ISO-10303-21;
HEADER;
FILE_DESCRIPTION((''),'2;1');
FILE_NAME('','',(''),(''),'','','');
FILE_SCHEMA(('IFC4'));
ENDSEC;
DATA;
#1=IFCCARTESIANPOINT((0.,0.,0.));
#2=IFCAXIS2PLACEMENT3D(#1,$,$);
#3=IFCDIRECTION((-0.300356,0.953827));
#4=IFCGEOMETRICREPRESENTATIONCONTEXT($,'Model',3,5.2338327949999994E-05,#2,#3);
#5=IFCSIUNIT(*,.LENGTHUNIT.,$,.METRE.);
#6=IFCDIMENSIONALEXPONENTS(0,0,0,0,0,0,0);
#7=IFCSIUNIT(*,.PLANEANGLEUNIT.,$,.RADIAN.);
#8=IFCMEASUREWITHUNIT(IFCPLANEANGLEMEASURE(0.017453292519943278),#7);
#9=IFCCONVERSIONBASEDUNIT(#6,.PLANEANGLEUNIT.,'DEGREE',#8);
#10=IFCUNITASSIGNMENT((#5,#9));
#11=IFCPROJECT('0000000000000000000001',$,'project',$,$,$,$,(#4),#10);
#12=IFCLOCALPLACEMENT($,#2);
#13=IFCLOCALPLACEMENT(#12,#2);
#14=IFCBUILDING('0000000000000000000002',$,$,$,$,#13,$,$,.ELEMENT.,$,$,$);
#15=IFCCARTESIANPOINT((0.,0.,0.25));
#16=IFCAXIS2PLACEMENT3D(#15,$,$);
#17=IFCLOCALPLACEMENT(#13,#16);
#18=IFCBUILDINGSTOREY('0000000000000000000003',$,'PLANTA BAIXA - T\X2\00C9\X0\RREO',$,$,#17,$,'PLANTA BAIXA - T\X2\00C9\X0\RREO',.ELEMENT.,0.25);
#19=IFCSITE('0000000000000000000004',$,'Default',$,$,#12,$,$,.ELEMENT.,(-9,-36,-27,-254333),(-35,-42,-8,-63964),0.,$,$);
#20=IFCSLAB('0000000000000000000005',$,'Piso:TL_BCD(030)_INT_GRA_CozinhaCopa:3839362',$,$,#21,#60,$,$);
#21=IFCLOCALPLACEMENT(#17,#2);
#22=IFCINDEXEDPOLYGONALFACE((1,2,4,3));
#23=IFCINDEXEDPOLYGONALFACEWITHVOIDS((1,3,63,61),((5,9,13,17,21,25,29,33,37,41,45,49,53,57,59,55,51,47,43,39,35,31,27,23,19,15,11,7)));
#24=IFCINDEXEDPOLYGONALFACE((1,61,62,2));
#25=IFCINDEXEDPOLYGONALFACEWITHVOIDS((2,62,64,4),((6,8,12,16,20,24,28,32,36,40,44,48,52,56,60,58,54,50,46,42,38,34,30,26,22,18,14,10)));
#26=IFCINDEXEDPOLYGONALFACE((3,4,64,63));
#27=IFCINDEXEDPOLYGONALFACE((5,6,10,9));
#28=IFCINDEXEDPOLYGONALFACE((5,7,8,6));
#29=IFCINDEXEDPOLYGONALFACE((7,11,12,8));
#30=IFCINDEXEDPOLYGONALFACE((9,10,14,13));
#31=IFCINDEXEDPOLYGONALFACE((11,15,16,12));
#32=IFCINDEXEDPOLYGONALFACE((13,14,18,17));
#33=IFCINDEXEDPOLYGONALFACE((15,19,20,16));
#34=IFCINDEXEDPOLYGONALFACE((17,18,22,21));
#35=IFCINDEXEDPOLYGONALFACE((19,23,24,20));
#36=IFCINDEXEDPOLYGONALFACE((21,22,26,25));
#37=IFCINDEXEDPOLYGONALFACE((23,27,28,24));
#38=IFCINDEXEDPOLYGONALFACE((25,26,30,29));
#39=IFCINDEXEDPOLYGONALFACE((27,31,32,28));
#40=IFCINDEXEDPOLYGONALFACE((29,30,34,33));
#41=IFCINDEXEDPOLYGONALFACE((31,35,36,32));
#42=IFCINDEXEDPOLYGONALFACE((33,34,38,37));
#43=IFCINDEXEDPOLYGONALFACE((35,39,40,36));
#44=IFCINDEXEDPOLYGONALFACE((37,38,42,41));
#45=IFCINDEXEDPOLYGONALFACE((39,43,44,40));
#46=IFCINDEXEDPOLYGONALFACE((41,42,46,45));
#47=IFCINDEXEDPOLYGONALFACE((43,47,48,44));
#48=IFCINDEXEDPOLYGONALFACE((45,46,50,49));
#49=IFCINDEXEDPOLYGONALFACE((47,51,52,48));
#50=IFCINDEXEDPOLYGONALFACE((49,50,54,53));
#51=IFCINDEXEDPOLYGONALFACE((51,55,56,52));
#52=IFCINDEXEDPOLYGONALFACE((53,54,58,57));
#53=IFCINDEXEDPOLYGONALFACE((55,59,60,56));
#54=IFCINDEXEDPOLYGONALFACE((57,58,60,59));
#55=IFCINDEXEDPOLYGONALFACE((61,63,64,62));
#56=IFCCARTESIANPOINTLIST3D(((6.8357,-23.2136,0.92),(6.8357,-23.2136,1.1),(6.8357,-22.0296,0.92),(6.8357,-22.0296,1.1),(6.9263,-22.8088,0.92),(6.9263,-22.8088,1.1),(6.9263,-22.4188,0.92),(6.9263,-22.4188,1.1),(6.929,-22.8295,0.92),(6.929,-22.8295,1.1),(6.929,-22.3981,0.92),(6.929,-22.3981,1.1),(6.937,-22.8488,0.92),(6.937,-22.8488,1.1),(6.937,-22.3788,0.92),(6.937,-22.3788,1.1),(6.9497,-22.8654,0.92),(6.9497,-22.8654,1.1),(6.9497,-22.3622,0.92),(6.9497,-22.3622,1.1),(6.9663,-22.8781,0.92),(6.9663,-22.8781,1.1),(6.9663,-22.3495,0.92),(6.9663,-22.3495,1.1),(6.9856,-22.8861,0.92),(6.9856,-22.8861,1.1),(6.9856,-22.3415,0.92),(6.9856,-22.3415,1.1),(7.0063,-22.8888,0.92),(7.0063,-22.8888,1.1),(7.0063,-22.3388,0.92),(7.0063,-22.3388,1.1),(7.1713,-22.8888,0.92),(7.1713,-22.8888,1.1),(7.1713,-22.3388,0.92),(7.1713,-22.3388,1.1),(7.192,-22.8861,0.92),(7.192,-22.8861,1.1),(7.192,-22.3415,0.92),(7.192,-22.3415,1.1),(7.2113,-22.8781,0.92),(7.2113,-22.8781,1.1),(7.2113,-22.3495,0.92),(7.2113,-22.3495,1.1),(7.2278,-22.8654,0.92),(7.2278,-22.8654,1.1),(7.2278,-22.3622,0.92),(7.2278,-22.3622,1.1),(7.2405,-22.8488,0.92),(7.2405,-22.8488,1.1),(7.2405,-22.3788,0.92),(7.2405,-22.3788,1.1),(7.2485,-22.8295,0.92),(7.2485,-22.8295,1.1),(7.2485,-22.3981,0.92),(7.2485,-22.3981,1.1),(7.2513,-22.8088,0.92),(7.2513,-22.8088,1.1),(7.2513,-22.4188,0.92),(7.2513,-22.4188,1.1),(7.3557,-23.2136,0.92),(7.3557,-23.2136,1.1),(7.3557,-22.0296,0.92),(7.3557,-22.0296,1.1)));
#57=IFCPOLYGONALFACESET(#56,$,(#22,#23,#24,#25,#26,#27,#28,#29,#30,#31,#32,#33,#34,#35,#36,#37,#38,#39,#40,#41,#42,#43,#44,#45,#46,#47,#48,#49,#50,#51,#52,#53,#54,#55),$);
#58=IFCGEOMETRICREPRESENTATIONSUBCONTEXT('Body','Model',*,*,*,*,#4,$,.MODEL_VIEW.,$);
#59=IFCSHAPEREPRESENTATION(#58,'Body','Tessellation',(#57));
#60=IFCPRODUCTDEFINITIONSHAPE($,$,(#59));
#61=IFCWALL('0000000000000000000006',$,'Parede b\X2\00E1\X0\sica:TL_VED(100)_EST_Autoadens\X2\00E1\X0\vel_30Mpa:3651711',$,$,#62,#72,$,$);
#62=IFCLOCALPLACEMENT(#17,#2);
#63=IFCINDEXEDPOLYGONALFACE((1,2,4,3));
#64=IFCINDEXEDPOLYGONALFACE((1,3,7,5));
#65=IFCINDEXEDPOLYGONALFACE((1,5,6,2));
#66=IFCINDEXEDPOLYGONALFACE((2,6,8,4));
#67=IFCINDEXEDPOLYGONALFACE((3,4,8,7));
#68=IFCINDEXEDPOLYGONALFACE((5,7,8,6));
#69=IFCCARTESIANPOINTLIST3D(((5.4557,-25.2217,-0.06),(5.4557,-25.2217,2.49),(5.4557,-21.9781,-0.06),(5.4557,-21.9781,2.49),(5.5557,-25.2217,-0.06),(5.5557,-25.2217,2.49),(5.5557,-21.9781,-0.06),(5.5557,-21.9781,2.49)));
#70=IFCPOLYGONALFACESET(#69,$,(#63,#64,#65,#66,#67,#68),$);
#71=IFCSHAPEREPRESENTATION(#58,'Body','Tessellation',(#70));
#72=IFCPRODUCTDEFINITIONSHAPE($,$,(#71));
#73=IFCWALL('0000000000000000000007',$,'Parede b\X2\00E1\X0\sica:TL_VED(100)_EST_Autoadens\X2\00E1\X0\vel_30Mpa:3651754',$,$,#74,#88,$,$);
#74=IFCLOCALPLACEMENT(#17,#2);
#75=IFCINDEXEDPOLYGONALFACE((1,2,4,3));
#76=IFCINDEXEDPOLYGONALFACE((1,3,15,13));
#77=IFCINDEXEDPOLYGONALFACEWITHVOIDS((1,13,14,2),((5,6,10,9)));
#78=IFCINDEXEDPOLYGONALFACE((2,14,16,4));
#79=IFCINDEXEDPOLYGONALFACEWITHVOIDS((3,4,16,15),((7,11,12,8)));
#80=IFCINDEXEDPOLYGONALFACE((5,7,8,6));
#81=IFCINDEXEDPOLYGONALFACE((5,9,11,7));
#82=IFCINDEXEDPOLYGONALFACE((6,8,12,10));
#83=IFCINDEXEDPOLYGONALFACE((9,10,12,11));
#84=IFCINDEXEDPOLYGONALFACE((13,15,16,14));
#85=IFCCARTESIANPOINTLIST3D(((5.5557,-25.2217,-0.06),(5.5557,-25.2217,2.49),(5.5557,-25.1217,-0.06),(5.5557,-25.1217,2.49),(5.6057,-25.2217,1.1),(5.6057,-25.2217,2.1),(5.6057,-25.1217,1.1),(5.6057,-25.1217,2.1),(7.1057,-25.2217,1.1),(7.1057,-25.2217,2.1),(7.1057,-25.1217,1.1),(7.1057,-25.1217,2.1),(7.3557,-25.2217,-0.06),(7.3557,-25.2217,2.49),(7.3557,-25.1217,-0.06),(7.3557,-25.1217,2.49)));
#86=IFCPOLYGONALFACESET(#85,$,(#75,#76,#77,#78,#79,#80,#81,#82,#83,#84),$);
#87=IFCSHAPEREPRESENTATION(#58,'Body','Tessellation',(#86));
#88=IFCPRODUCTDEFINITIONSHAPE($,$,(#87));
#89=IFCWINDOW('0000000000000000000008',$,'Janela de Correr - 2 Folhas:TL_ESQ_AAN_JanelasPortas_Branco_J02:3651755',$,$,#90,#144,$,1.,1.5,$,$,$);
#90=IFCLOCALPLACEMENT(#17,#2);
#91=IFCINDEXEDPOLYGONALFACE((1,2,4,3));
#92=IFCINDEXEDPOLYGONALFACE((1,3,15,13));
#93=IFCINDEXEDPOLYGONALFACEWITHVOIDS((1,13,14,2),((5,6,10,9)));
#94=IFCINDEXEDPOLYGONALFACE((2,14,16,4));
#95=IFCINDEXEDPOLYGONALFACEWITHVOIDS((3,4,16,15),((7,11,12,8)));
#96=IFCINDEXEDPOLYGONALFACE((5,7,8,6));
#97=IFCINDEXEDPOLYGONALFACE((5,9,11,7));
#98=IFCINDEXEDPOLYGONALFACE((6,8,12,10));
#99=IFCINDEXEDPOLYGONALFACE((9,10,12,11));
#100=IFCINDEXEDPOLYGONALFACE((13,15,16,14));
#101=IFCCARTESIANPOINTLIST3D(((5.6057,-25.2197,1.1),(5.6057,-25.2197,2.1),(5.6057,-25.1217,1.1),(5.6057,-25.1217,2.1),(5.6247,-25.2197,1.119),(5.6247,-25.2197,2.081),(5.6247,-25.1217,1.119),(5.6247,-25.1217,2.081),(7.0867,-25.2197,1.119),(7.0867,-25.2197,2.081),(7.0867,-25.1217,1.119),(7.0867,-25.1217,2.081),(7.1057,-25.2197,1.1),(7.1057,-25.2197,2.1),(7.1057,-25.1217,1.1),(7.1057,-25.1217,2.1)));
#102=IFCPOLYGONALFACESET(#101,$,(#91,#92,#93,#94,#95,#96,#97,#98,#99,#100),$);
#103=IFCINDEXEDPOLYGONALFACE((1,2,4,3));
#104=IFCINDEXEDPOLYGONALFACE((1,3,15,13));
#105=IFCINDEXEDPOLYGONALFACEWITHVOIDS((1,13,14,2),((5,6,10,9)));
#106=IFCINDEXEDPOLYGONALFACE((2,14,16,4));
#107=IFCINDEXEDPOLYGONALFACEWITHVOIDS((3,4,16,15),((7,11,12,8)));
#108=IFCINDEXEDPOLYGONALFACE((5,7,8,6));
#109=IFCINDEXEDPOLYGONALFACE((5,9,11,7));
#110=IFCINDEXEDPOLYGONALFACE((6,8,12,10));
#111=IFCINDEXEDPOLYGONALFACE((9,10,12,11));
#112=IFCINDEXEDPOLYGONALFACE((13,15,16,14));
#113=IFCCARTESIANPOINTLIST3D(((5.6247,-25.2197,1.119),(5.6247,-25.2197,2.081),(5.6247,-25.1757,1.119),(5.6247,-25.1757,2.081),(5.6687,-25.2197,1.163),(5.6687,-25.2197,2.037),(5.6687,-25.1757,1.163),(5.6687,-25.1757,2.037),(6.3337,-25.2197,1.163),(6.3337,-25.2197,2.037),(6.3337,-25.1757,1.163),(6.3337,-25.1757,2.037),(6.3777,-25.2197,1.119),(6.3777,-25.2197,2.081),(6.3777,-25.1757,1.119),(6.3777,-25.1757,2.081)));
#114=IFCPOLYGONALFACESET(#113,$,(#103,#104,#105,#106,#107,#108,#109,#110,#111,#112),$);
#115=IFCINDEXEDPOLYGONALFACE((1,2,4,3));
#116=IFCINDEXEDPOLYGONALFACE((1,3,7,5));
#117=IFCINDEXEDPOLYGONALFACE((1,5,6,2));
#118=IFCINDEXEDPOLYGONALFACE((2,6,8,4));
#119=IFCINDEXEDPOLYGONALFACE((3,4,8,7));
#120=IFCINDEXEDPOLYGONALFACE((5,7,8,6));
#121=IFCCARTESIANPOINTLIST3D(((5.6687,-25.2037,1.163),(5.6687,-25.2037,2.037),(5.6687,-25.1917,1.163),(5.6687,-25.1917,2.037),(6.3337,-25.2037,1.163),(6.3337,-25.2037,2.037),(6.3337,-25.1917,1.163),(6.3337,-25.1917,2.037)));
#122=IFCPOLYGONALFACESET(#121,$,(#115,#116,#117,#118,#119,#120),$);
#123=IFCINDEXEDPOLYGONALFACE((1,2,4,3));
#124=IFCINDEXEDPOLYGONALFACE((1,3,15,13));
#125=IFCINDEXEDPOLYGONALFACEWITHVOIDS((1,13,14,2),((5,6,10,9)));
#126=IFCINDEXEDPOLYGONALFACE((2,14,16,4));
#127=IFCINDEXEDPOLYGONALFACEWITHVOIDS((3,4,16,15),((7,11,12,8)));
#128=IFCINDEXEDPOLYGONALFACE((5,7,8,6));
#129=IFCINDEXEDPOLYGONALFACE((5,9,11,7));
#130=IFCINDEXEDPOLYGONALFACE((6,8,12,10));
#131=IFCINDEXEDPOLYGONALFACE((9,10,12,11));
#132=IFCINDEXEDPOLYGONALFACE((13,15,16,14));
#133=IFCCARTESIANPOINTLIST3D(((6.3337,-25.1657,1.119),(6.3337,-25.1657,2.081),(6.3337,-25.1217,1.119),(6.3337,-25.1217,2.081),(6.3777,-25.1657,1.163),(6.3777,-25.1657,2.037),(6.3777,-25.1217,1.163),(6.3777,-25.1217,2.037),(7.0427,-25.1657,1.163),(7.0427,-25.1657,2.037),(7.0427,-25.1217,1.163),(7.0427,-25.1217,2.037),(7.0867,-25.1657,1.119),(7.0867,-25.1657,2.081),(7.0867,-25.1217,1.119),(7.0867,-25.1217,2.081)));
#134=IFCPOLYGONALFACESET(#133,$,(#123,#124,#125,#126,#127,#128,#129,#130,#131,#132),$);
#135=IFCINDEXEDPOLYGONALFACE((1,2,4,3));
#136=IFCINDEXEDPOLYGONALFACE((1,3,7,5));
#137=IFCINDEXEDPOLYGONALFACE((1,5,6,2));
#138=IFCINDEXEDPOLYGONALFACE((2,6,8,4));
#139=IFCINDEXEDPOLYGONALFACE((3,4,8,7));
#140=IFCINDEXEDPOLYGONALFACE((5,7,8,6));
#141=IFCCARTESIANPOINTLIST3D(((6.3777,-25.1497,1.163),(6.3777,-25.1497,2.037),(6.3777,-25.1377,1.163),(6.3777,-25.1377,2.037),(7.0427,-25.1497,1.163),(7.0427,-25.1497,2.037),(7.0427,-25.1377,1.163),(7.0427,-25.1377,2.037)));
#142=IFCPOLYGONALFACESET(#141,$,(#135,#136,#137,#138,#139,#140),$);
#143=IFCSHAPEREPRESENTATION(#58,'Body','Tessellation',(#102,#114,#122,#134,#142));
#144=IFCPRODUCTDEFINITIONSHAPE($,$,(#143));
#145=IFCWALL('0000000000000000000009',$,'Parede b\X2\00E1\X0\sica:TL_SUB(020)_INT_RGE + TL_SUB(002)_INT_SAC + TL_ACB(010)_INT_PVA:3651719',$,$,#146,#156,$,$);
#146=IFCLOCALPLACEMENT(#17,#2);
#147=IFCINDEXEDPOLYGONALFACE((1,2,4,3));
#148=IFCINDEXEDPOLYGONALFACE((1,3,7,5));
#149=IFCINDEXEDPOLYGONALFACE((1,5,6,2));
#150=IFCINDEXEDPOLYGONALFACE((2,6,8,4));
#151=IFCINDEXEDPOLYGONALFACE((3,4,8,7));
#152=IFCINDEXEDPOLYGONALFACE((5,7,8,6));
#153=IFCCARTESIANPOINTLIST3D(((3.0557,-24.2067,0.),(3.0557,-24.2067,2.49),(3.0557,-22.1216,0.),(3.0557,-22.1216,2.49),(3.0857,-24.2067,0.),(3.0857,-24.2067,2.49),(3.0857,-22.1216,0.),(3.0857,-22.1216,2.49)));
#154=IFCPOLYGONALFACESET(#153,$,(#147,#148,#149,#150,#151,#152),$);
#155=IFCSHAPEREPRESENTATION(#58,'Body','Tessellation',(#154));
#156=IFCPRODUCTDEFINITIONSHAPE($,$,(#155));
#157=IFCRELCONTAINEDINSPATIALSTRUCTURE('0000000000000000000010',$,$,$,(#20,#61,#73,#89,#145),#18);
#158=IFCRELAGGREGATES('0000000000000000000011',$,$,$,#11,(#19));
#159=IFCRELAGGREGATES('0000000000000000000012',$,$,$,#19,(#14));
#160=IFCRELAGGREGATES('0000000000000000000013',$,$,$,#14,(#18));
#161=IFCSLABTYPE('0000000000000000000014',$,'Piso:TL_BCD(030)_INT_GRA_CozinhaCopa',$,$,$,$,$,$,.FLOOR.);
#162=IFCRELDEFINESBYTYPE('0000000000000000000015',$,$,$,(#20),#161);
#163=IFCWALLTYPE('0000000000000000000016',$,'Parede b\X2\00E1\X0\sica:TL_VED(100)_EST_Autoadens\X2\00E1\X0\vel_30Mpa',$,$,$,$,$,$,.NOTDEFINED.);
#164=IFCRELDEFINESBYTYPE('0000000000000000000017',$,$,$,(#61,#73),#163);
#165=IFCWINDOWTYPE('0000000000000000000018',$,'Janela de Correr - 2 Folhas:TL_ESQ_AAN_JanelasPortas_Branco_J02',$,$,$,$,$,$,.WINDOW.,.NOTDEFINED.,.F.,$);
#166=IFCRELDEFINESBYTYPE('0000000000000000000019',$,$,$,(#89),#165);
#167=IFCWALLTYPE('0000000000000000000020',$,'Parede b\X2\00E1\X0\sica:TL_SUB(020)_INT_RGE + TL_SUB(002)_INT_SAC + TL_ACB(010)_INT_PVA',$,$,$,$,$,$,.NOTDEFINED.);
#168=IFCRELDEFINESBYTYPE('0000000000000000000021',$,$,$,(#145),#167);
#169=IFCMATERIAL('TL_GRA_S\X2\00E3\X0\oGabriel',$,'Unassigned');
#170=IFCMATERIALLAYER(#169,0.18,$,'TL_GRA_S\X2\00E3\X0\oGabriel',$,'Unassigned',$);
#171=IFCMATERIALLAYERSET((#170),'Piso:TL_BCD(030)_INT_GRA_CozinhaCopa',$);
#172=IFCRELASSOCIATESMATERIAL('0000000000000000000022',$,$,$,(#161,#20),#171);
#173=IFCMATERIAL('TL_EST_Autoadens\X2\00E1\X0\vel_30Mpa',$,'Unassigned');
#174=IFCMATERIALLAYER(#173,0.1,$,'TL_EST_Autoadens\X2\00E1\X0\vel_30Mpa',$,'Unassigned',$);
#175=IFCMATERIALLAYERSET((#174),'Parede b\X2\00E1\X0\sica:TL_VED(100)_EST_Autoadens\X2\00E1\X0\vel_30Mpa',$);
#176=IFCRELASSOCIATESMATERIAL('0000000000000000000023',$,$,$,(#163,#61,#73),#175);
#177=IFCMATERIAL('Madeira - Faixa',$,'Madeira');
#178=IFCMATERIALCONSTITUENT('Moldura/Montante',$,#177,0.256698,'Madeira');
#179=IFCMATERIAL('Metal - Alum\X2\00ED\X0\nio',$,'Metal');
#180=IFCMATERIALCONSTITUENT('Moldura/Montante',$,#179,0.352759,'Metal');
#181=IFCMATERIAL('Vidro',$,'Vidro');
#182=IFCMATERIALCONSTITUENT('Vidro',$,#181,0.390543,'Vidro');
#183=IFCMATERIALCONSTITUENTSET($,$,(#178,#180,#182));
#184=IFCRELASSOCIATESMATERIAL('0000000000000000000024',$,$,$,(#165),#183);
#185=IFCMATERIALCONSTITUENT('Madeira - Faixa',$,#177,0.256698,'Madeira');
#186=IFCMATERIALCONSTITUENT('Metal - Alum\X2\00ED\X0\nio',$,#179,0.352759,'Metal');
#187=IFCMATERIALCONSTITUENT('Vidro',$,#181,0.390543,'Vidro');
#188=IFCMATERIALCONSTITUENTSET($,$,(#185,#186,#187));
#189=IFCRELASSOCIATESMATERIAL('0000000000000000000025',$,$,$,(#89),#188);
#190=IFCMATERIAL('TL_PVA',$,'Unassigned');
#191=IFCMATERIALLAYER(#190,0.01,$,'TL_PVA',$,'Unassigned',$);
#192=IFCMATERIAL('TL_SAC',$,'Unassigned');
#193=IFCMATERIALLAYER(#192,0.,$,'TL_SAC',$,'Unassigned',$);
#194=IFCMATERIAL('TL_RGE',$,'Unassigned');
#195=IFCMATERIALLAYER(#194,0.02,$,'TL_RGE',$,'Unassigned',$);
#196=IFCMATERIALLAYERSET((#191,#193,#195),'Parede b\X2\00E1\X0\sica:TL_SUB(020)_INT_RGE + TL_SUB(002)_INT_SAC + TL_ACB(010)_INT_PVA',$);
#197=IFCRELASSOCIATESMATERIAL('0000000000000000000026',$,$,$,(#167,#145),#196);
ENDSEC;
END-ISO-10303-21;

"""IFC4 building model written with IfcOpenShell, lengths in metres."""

from ifc_helpers import new_model, entity, si_unit, converted_unit, direction, frame, frame_2d, origin, origin_2d_with_axis, place, context, subcontext, project, spatial, polyline, circle_curve, parameter, trimmed, segment, composite_curve, rectangle, outline, extrude, source, transform, mapped, material, layer, layer_set, layer_usage, constituent, constituent_set, type_object, type_shapes, element, fill, save


model = new_model("IFC4")

# Units and contexts
model_context = context("Model", 3, precision=5.2338327949999994e-05, world=origin(), true_north=direction((-0.300356, 0.953827)))
body_context = subcontext(model_context, "Body", "Model", "MODEL_VIEW")
ifc_project = project(units=[si_unit("LENGTHUNIT", "METRE"), converted_unit("PLANEANGLEUNIT", "DEGREE", entity("IfcPlaneAngleMeasure", 0.017453292519943278), si_unit("PLANEANGLEUNIT", "RADIAN"), dimensions=[0, 0, 0, 0, 0, 0, 0])], contexts=[model_context])

# Site, building, storey
site_placement = place(None, origin())
site = spatial("IfcSite", under=ifc_project, at=site_placement, Name="Default", CompositionType="ELEMENT", RefLatitude=(-9, -36, -27, -254333), RefLongitude=(-35, -42, -8, -63964), RefElevation=0.0)
building_placement = place(site_placement, origin())
building = spatial("IfcBuilding", under=site, at=building_placement, CompositionType="ELEMENT")
storey_placement = place(building_placement, frame((0.0, 0.0, 0.25)))
storey = spatial("IfcBuildingStorey", under=building, at=storey_placement, Name="PLANTA BAIXA - TÉRREO", LongName="PLANTA BAIXA - TÉRREO", CompositionType="ELEMENT", Elevation=0.25)

# Slab, opening
ifc_material_1 = material(Name="TL_GRA_SãoGabriel", Category="Unassigned")
ifc_layer_1 = layer(ifc_material_1, 0.18, Name="TL_GRA_SãoGabriel", Category="Unassigned")
ifc_layer_set_1 = layer_set([ifc_layer_1], Name="Piso:TL_BCD(030)_INT_GRA_CozinhaCopa")
ifc_layer_usage_1 = layer_usage(ifc_layer_set_1, "AXIS3", "POSITIVE", 0.0)
slab_type = type_object("IfcSlabType", Name="Piso:TL_BCD(030)_INT_GRA_CozinhaCopa", PredefinedType="FLOOR", material=ifc_layer_set_1)
slab_placement = place(storey_placement, frame((6.8357, -23.2136, 0.92)))
slab = element("IfcSlab", 1, at=slab_placement, inside=storey, type_object=slab_type, material=ifc_layer_usage_1, Name="Piso:TL_BCD(030)_INT_GRA_CozinhaCopa:3839362", context=body_context, shape_type="SweptSolid", body=[
    extrude(rectangle(XDim=0.52, YDim=1.184, at=origin_2d_with_axis()), frame((0.26, 0.592, 0.18), z_axis=(0.0, 0.0, -1.0), x_axis=(-1.0, 0.0, 0.0)), (0.0, 0.0, 1.0), 0.18),
])
opening_1_placement = place(slab_placement, frame((-6.8357, 23.2136, 0.18)))
element("IfcOpeningElement", 2, at=opening_1_placement, cuts=slab, PredefinedType="OPENING", context=body_context, shape_type="SweptSolid", body=[
    extrude(outline(composite_curve([segment(trimmed(circle_curve(frame_2d((0.195, -0.0825), x_axis=(1.0, 0.0)), 0.08), [parameter(270.0)], [parameter(0.0)], True, "PARAMETER"), True, "CONTINUOUS"), segment(polyline([(0.275, -0.0825), (0.275, 0.0825)]), True, "CONTINUOUS"), segment(trimmed(circle_curve(frame_2d((0.195, 0.0825), x_axis=(1.0, 0.0)), 0.08), [parameter(0.0)], [parameter(90.0)], True, "PARAMETER"), True, "CONTINUOUS"), segment(polyline([(0.195, 0.1625), (-0.195, 0.1625)]), True, "CONTINUOUS"), segment(trimmed(circle_curve(frame_2d((-0.195, 0.0825), x_axis=(1.0, 0.0)), 0.08), [parameter(90.0)], [parameter(180.0)], True, "PARAMETER"), True, "CONTINUOUS"), segment(polyline([(-0.275, 0.0825), (-0.275, -0.0825)]), True, "CONTINUOUS"), segment(trimmed(circle_curve(frame_2d((-0.195, -0.0825), x_axis=(1.0, 0.0)), 0.08), [parameter(180.0)], [parameter(270.0)], True, "PARAMETER"), True, "CONTINUOUS"), segment(polyline([(-0.195, -0.1625), (0.195, -0.1625)]), True, "CONTINUOUS")], self_intersect=False)), frame((7.0888, -22.6138, -0.21), z_axis=(0.0, 0.0, 1.0), x_axis=(0.0, 1.0, 0.0)), (0.0, 0.0, 1.0), 0.21),
])

# Wall
ifc_material_2 = material(Name="TL_EST_Autoadensável_30Mpa", Category="Unassigned")
ifc_layer_2 = layer(ifc_material_2, 0.1, Name="TL_EST_Autoadensável_30Mpa", Category="Unassigned")
ifc_layer_set_2 = layer_set([ifc_layer_2], Name="Parede básica:TL_VED(100)_EST_Autoadensável_30Mpa")
ifc_layer_usage_2 = layer_usage(ifc_layer_set_2, "AXIS2", "POSITIVE", -0.05)
wall_type_1 = type_object("IfcWallType", Name="Parede básica:TL_VED(100)_EST_Autoadensável_30Mpa", PredefinedType="NOTDEFINED", material=ifc_layer_set_2)
wall_1_placement = place(storey_placement, frame((5.5057, -25.2217, -0.06), z_axis=(0.0, 0.0, 1.0), x_axis=(0.0, 1.0, 0.0)))
element("IfcWall", 3, at=wall_1_placement, inside=storey, type_object=wall_type_1, material=ifc_layer_usage_2, Name="Parede básica:TL_VED(100)_EST_Autoadensável_30Mpa:3651711", context=body_context, shape_type="SweptSolid", body=[
    extrude(rectangle(XDim=3.2437, YDim=0.1, at=frame_2d((1.6218, 0.0), x_axis=(-1.0, 0.0))), origin(), (0.0, 0.0, 1.0), 2.55),
])

# Wall, opening, window
ifc_layer_usage_3 = layer_usage(ifc_layer_set_2, "AXIS2", "POSITIVE", -0.05)
wall_2_placement = place(storey_placement, frame((5.5557, -25.1717, -0.06)))
wall_2 = element("IfcWall", 4, at=wall_2_placement, inside=storey, type_object=wall_type_1, material=ifc_layer_usage_3, Name="Parede básica:TL_VED(100)_EST_Autoadensável_30Mpa:3651754", context=body_context, shape_type="SweptSolid", body=[
    extrude(rectangle(XDim=1.8, YDim=0.1, at=frame_2d((0.9, 0.0), x_axis=(-1.0, 0.0))), origin(), (0.0, 0.0, 1.0), 2.55),
])
opening_2_placement = place(wall_2_placement, frame((1.55, 0.05, 1.16)))
opening_2 = element("IfcOpeningElement", 5, at=opening_2_placement, cuts=wall_2, PredefinedType="OPENING", context=body_context, shape_type="SweptSolid", body=[
    extrude(rectangle(XDim=1.0, YDim=1.5, at=frame_2d((0.5, 0.75), x_axis=(-1.0, 0.0))), frame((0.0, 0.0, 0.0), z_axis=(0.0, -1.0, 0.0), x_axis=(0.0, 0.0, 1.0)), (0.0, 0.0, 1.0), 0.1),
])
ifc_material_3 = material(Name="Madeira - Faixa", Category="Madeira")
ifc_constituent_1 = constituent(ifc_material_3, Name="Madeira - Faixa", Category="Madeira", fraction=0.256698)
ifc_material_4 = material(Name="Metal - Alumínio", Category="Metal")
ifc_constituent_2 = constituent(ifc_material_4, Name="Metal - Alumínio", Category="Metal", fraction=0.352759)
ifc_material_5 = material(Name="Vidro", Category="Vidro")
ifc_constituent_3 = constituent(ifc_material_5, Name="Vidro", Category="Vidro", fraction=0.390543)
ifc_constituent_set_1 = constituent_set(constituents=[ifc_constituent_1, ifc_constituent_2, ifc_constituent_3])
ifc_constituent_4 = constituent(ifc_material_3, Name="Moldura/Montante", Category="Madeira", fraction=0.256698)
ifc_constituent_5 = constituent(ifc_material_4, Name="Moldura/Montante", Category="Metal", fraction=0.352759)
ifc_constituent_6 = constituent(ifc_material_5, Name="Vidro", Category="Vidro", fraction=0.390543)
ifc_constituent_set_2 = constituent_set(constituents=[ifc_constituent_4, ifc_constituent_5, ifc_constituent_6])
window_type = type_object("IfcWindowType", Name="Janela de Correr - 2 Folhas:TL_ESQ_AAN_JanelasPortas_Branco_J02", ParameterTakesPrecedence=False, PartitioningType="NOTDEFINED", PredefinedType="WINDOW", material=ifc_constituent_set_2)
shared_shape_1 = source(origin(), body_context, "Body", "SweptSolid", [
    extrude(outline(polyline([(-0.75, -0.5), (0.75, -0.5), (0.75, 0.5), (-0.75, 0.5), (-0.75, -0.5)]), holes=[polyline([(-0.731, -0.481), (-0.731, 0.481), (0.731, 0.481), (0.731, -0.481), (-0.731, -0.481)])]), frame((0.75, 0.0, 0.5), z_axis=(0.0, 1.0, 0.0), x_axis=(1.0, 0.0, 0.0)), (0.0, 0.0, 1.0), 0.098),
    extrude(outline(polyline([(-0.3765, -0.481), (0.3765, -0.481), (0.3765, 0.481), (-0.3765, 0.481), (-0.3765, -0.481)]), holes=[polyline([(-0.3325, -0.437), (-0.3325, 0.437), (0.3325, 0.437), (0.3325, -0.437), (-0.3325, -0.437)])]), frame((1.1045, 0.054, 0.5), z_axis=(0.0, 1.0, 0.0), x_axis=(1.0, 0.0, 0.0)), (0.0, 0.0, 1.0), 0.044),
    extrude(rectangle(XDim=0.012, YDim=0.665, at=origin_2d_with_axis()), frame((1.1045, 0.076, 0.063), z_axis=(0.0, 0.0, 1.0), x_axis=(0.0, -1.0, 0.0)), (0.0, 0.0, 1.0), 0.874),
    extrude(outline(polyline([(-0.481, -0.3765), (0.481, -0.3765), (0.481, 0.3765), (-0.481, 0.3765), (-0.481, -0.3765)]), holes=[polyline([(-0.437, -0.3325), (-0.437, 0.3325), (0.437, 0.3325), (0.437, -0.3325), (-0.437, -0.3325)])]), frame((0.3955, 0.0, 0.5), z_axis=(0.0, 1.0, 0.0), x_axis=(0.0, 0.0, -1.0)), (0.0, 0.0, 1.0), 0.044),
    extrude(rectangle(XDim=0.012, YDim=0.665, at=origin_2d_with_axis()), frame((0.3955, 0.022, 0.063), z_axis=(0.0, 0.0, 1.0), x_axis=(0.0, -1.0, 0.0)), (0.0, 0.0, 1.0), 0.874),
])
type_shapes(window_type, [shared_shape_1])
window_placement = place(opening_2_placement, frame((0.0, 0.0, 0.0), z_axis=(0.0, 0.0, 1.0), x_axis=(-1.0, 0.0, 0.0)))
window = element("IfcWindow", 6, at=window_placement, inside=storey, type_object=window_type, material=ifc_constituent_set_1, Name="Janela de Correr - 2 Folhas:TL_ESQ_AAN_JanelasPortas_Branco_J02:3651755", OverallHeight=1.0, OverallWidth=1.5, context=body_context, shape_type="MappedRepresentation", body=[
    mapped(shared_shape_1, transform((0.0, 0.0, 0.0), scale=1.0)),
])
fill(opening_2, window)

# Wall
ifc_material_6 = material(Name="TL_PVA", Category="Unassigned")
ifc_layer_3 = layer(ifc_material_6, 0.01, Name="TL_PVA", Category="Unassigned")
ifc_material_7 = material(Name="TL_SAC", Category="Unassigned")
ifc_layer_4 = layer(ifc_material_7, 0.0, Name="TL_SAC", Category="Unassigned")
ifc_material_8 = material(Name="TL_RGE", Category="Unassigned")
ifc_layer_5 = layer(ifc_material_8, 0.02, Name="TL_RGE", Category="Unassigned")
ifc_layer_set_3 = layer_set([ifc_layer_3, ifc_layer_4, ifc_layer_5], Name="Parede básica:TL_SUB(020)_INT_RGE + TL_SUB(002)_INT_SAC + TL_ACB(010)_INT_PVA")
ifc_layer_usage_4 = layer_usage(ifc_layer_set_3, "AXIS2", "POSITIVE", -0.015)
wall_type_2 = type_object("IfcWallType", Name="Parede básica:TL_SUB(020)_INT_RGE + TL_SUB(002)_INT_SAC + TL_ACB(010)_INT_PVA", PredefinedType="NOTDEFINED", material=ifc_layer_set_3)
wall_3_placement = place(storey_placement, frame((3.0707, -24.2067, 0.0), z_axis=(0.0, 0.0, 1.0), x_axis=(0.0, 1.0, 0.0)))
element("IfcWall", 7, at=wall_3_placement, inside=storey, type_object=wall_type_2, material=ifc_layer_usage_4, Name="Parede básica:TL_SUB(020)_INT_RGE + TL_SUB(002)_INT_SAC + TL_ACB(010)_INT_PVA:3651719", context=body_context, shape_type="SweptSolid", body=[
    extrude(rectangle(XDim=2.0851, YDim=0.03, at=frame_2d((1.0426, 0.0), x_axis=(-1.0, 0.0))), origin(), (0.0, 0.0, 1.0), 2.49),
])

save(model, "model.ifc")
